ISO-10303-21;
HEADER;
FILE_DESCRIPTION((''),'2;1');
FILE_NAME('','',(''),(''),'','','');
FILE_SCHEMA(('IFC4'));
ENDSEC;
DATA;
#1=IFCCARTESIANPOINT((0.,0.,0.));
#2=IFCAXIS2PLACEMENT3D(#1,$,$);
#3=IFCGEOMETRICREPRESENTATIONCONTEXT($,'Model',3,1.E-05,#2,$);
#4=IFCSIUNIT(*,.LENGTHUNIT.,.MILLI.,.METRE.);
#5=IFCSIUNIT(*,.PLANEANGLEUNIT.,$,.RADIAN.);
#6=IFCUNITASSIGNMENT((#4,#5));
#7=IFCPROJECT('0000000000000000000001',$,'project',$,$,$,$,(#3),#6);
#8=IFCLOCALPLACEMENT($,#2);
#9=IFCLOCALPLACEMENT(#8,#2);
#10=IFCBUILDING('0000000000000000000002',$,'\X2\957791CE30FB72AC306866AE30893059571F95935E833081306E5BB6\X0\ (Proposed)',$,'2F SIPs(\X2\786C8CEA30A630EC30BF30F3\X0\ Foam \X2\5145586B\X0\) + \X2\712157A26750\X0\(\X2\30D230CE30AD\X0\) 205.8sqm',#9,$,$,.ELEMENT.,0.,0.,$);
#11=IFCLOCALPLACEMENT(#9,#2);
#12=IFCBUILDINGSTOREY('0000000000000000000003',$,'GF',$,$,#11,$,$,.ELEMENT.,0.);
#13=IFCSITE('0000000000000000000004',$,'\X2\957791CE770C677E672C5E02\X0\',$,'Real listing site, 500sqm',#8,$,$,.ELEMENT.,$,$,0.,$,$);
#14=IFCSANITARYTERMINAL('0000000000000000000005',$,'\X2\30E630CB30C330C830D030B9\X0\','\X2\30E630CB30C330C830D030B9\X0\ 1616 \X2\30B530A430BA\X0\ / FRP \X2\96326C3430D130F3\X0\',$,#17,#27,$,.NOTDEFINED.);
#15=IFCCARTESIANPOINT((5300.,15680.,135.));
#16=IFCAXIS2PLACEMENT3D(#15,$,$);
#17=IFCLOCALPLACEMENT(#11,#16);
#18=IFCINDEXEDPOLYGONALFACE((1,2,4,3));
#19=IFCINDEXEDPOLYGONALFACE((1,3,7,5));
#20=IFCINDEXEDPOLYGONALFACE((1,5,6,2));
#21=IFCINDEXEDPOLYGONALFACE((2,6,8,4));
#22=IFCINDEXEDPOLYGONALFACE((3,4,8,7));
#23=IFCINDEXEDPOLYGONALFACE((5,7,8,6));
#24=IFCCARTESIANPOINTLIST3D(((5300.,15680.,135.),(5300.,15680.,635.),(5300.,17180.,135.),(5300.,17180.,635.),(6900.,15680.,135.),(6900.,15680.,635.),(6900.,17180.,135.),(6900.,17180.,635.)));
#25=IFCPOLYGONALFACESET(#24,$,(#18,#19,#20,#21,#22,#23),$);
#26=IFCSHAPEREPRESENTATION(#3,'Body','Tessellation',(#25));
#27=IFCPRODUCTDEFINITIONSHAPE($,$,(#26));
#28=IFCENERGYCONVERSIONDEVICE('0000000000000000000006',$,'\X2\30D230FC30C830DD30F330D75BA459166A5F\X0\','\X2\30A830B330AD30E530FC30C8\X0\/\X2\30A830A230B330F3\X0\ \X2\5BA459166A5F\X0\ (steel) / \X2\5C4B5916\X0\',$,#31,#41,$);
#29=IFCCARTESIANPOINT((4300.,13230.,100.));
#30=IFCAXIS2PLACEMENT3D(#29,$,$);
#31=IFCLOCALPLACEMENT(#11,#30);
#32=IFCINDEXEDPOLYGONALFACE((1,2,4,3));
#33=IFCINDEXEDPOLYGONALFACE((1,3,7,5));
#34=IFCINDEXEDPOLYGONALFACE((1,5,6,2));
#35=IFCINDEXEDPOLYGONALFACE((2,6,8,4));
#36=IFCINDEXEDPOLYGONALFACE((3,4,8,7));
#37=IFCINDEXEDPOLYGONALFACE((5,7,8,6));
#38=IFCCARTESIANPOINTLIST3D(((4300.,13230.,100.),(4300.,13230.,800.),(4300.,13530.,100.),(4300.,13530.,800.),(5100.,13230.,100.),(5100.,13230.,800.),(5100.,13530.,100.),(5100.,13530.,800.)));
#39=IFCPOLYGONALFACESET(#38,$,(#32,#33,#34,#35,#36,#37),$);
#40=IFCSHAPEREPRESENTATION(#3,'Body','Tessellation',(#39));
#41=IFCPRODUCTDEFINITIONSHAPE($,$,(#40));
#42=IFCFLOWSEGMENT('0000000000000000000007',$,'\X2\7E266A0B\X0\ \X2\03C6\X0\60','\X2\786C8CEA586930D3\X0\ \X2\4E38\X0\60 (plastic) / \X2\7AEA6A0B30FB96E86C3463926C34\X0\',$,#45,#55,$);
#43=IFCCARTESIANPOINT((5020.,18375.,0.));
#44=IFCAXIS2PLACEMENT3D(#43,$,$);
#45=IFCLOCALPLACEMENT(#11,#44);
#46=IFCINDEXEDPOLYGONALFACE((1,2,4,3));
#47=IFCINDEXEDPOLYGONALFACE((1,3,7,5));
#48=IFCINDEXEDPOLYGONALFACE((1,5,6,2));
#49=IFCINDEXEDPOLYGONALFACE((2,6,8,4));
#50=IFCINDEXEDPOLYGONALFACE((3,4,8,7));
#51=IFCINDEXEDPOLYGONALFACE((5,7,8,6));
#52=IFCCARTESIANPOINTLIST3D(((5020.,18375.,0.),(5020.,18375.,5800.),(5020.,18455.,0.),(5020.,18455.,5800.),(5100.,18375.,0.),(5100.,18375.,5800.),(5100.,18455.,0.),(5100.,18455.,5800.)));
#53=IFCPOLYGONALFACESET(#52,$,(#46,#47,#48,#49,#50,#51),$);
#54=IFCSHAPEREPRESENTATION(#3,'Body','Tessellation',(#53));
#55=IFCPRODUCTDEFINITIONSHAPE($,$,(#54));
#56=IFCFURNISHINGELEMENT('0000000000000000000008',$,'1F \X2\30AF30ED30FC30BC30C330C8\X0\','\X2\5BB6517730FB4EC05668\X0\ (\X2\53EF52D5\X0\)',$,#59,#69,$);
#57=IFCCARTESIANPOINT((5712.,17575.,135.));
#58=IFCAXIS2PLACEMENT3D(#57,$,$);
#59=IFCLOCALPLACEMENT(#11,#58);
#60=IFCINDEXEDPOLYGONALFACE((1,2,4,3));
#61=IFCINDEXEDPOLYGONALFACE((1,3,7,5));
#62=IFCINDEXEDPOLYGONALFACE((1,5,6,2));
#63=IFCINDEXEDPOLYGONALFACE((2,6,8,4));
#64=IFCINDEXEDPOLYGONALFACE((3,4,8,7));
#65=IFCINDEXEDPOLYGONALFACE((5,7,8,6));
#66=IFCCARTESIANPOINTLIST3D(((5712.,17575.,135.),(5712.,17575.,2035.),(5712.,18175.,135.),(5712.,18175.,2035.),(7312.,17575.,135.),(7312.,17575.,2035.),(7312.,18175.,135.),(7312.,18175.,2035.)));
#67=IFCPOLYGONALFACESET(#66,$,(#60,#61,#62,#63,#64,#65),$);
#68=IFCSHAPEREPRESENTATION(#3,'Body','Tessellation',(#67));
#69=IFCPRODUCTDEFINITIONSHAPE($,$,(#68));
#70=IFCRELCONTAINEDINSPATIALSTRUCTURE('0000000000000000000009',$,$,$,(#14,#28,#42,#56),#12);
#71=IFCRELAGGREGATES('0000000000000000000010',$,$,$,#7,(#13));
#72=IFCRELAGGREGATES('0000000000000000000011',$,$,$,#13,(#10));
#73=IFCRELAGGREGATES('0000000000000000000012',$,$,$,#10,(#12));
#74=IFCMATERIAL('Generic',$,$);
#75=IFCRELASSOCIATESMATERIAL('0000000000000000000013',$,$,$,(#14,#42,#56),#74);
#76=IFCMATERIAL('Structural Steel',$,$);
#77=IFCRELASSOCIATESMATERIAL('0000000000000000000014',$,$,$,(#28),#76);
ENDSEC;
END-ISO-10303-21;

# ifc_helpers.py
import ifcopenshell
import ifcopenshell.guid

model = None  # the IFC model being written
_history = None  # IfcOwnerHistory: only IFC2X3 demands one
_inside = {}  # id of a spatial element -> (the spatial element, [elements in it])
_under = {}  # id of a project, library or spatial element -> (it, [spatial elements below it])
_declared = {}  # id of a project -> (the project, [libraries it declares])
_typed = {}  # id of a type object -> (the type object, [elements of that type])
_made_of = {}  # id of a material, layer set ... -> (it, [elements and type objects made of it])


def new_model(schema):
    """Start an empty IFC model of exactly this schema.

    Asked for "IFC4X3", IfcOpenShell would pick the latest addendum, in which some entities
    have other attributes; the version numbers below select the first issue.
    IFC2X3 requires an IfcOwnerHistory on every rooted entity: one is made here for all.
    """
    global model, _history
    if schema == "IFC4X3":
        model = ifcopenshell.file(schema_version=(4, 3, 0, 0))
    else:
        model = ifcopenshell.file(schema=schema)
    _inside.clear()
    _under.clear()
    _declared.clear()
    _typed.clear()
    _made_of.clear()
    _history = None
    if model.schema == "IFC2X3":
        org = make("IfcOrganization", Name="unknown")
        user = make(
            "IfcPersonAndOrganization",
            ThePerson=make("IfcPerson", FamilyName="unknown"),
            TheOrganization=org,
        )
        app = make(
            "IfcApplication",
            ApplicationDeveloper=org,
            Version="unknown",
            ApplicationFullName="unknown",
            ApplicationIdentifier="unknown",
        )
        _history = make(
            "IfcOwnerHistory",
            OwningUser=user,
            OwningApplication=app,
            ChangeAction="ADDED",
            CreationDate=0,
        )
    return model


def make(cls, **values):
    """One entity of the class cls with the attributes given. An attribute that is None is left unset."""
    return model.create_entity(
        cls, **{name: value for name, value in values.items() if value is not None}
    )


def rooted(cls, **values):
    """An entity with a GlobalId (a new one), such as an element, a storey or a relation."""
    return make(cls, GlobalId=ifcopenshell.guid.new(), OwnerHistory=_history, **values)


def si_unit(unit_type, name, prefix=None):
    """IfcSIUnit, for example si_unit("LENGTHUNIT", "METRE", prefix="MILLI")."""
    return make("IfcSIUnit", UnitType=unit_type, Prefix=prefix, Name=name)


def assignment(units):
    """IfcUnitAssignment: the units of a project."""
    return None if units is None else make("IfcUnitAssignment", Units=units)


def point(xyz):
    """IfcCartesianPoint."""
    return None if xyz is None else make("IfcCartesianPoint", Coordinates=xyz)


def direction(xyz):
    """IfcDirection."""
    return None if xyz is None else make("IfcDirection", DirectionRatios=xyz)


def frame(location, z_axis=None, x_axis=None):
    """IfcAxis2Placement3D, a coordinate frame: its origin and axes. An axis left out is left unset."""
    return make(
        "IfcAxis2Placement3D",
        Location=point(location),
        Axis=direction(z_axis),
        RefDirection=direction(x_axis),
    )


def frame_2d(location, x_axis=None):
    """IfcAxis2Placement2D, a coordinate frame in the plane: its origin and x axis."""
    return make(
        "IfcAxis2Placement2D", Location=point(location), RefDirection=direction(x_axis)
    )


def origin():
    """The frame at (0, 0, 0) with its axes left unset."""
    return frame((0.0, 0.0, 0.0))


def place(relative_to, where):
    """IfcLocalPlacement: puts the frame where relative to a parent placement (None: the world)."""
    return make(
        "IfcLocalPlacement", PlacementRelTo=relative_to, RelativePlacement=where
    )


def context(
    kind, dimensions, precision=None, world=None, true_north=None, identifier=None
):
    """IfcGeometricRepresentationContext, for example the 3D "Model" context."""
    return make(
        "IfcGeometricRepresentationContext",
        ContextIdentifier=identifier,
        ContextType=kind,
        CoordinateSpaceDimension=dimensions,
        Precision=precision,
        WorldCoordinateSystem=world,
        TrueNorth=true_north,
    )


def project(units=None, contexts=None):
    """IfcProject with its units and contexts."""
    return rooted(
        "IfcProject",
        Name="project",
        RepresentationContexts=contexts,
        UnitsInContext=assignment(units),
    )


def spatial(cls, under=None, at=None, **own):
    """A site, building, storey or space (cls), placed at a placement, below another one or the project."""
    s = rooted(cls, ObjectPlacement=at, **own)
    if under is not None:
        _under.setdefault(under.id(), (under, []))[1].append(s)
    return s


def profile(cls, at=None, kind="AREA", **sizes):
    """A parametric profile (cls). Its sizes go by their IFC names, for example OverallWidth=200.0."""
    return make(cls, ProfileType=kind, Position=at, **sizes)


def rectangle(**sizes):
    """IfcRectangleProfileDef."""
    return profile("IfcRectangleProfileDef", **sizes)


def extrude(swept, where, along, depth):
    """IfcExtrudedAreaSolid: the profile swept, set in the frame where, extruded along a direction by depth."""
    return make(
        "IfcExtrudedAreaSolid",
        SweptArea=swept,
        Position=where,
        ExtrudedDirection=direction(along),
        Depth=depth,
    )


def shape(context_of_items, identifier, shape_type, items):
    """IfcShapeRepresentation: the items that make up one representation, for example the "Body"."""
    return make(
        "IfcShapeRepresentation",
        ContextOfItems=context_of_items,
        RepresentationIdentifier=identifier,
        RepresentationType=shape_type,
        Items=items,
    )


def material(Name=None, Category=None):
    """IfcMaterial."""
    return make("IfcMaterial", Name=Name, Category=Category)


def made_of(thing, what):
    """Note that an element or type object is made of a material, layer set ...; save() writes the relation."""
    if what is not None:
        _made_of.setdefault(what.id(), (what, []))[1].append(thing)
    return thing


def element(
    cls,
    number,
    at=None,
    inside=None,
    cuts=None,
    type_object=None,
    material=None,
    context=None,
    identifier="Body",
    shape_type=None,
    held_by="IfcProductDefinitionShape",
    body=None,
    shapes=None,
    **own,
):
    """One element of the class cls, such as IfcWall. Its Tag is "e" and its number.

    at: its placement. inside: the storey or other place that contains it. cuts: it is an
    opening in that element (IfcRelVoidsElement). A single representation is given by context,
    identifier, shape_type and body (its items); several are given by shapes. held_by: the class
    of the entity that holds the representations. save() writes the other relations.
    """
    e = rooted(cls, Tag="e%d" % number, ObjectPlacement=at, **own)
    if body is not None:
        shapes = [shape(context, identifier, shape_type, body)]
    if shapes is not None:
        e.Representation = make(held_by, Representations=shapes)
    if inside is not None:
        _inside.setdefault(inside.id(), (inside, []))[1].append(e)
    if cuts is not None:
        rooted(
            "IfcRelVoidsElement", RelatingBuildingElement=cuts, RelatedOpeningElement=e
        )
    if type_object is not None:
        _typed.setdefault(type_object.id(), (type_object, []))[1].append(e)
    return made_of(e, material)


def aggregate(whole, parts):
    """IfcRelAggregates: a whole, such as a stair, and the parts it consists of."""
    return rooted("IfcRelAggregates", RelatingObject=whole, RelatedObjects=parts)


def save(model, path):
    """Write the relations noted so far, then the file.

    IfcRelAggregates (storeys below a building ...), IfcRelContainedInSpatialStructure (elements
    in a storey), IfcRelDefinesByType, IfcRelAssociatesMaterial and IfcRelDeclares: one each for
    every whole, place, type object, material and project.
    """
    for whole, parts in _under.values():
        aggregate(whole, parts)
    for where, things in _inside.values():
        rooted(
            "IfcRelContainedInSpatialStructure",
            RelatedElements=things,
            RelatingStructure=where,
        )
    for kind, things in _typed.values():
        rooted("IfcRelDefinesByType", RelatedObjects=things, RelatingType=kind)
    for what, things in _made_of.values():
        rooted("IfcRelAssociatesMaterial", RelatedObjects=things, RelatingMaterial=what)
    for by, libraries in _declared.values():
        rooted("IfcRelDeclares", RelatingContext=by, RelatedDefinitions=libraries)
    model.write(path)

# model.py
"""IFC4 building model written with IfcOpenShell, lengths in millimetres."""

from ifc_helpers import new_model, si_unit, frame, frame_2d, origin, place, context, project, spatial, rectangle, extrude, material, element, save


model = new_model("IFC4")

# Units and contexts
model_context = context("Model", 3, precision=1e-05, world=origin())
ifc_project = project(units=[si_unit("LENGTHUNIT", "METRE", prefix="MILLI"), si_unit("PLANEANGLEUNIT", "RADIAN")], contexts=[model_context])

# Site, building, storey
site_placement = place(None, origin())
site = spatial("IfcSite", under=ifc_project, at=site_placement, Name="長野県松本市", ObjectType="Real listing site, 500sqm", CompositionType="ELEMENT", RefElevation=0.0)
building_placement = place(site_placement, origin())
building = spatial("IfcBuilding", under=site, at=building_placement, Name="長野・犬と暮らす土間広めの家 (Proposed)", ObjectType="2F SIPs(硬質ウレタン Foam 充填) + 無垢材(ヒノキ) 205.8sqm", CompositionType="ELEMENT", ElevationOfRefHeight=0.0, ElevationOfTerrain=0.0)
storey_placement = place(building_placement, origin())
storey = spatial("IfcBuildingStorey", under=building, at=storey_placement, Name="GF", CompositionType="ELEMENT", Elevation=0.0)

# Shared definitions
ifc_material_1 = material(Name="Generic")

# Sanitary terminal
sanitary_terminal_placement = place(storey_placement, frame((5300.0, 15680.0, 135.0)))
element("IfcSanitaryTerminal", 1, at=sanitary_terminal_placement, inside=storey, material=ifc_material_1, Name="ユニットバス", Description="ユニットバス 1616 サイズ / FRP 防水パン", PredefinedType="NOTDEFINED", context=model_context, shape_type="SweptSolid", body=[
    extrude(rectangle(XDim=1600.0, YDim=1500.0, at=frame_2d((800.0, 750.0))), frame((5300.0, 15680.0, 135.0)), (0.0, 0.0, 1.0), 500.0),
])

# Energy conversion device
ifc_material_2 = material(Name="Structural Steel")
energy_conversion_device_placement = place(storey_placement, frame((4300.0, 13230.0, 100.0)))
element("IfcEnergyConversionDevice", 2, at=energy_conversion_device_placement, inside=storey, material=ifc_material_2, Name="ヒートポンプ室外機", Description="エコキュート/エアコン 室外機 (steel) / 屋外", context=model_context, shape_type="SweptSolid", body=[
    extrude(rectangle(XDim=800.0, YDim=300.0, at=frame_2d((400.0, 150.0))), frame((4300.0, 13230.0, 100.0)), (0.0, 0.0, 1.0), 700.0),
])

# Flow segment
flow_segment_placement = place(storey_placement, frame((5020.0, 18375.0, 0.0)))
element("IfcFlowSegment", 3, at=flow_segment_placement, inside=storey, material=ifc_material_1, Name="縦樋 φ60", Description="硬質塩ビ 丸60 (plastic) / 竪樋・雨水排水", context=model_context, shape_type="SweptSolid", body=[
    extrude(rectangle(XDim=80.0, YDim=80.0, at=frame_2d((40.0, 40.0))), frame((5020.0, 18375.0, 0.0)), (0.0, 0.0, 1.0), 5800.0),
])

# Furnishing element
furnishing_placement = place(storey_placement, frame((5712.0, 17575.0, 135.0)))
element("IfcFurnishingElement", 4, at=furnishing_placement, inside=storey, material=ifc_material_1, Name="1F クローゼット", Description="家具・什器 (可動)", context=model_context, shape_type="SweptSolid", body=[
    extrude(rectangle(XDim=1600.0, YDim=600.0, at=frame_2d((800.0, 300.0))), frame((5712.0, 17575.0, 135.0)), (0.0, 0.0, 1.0), 1900.0),
])

save(model, "model.ifc")
